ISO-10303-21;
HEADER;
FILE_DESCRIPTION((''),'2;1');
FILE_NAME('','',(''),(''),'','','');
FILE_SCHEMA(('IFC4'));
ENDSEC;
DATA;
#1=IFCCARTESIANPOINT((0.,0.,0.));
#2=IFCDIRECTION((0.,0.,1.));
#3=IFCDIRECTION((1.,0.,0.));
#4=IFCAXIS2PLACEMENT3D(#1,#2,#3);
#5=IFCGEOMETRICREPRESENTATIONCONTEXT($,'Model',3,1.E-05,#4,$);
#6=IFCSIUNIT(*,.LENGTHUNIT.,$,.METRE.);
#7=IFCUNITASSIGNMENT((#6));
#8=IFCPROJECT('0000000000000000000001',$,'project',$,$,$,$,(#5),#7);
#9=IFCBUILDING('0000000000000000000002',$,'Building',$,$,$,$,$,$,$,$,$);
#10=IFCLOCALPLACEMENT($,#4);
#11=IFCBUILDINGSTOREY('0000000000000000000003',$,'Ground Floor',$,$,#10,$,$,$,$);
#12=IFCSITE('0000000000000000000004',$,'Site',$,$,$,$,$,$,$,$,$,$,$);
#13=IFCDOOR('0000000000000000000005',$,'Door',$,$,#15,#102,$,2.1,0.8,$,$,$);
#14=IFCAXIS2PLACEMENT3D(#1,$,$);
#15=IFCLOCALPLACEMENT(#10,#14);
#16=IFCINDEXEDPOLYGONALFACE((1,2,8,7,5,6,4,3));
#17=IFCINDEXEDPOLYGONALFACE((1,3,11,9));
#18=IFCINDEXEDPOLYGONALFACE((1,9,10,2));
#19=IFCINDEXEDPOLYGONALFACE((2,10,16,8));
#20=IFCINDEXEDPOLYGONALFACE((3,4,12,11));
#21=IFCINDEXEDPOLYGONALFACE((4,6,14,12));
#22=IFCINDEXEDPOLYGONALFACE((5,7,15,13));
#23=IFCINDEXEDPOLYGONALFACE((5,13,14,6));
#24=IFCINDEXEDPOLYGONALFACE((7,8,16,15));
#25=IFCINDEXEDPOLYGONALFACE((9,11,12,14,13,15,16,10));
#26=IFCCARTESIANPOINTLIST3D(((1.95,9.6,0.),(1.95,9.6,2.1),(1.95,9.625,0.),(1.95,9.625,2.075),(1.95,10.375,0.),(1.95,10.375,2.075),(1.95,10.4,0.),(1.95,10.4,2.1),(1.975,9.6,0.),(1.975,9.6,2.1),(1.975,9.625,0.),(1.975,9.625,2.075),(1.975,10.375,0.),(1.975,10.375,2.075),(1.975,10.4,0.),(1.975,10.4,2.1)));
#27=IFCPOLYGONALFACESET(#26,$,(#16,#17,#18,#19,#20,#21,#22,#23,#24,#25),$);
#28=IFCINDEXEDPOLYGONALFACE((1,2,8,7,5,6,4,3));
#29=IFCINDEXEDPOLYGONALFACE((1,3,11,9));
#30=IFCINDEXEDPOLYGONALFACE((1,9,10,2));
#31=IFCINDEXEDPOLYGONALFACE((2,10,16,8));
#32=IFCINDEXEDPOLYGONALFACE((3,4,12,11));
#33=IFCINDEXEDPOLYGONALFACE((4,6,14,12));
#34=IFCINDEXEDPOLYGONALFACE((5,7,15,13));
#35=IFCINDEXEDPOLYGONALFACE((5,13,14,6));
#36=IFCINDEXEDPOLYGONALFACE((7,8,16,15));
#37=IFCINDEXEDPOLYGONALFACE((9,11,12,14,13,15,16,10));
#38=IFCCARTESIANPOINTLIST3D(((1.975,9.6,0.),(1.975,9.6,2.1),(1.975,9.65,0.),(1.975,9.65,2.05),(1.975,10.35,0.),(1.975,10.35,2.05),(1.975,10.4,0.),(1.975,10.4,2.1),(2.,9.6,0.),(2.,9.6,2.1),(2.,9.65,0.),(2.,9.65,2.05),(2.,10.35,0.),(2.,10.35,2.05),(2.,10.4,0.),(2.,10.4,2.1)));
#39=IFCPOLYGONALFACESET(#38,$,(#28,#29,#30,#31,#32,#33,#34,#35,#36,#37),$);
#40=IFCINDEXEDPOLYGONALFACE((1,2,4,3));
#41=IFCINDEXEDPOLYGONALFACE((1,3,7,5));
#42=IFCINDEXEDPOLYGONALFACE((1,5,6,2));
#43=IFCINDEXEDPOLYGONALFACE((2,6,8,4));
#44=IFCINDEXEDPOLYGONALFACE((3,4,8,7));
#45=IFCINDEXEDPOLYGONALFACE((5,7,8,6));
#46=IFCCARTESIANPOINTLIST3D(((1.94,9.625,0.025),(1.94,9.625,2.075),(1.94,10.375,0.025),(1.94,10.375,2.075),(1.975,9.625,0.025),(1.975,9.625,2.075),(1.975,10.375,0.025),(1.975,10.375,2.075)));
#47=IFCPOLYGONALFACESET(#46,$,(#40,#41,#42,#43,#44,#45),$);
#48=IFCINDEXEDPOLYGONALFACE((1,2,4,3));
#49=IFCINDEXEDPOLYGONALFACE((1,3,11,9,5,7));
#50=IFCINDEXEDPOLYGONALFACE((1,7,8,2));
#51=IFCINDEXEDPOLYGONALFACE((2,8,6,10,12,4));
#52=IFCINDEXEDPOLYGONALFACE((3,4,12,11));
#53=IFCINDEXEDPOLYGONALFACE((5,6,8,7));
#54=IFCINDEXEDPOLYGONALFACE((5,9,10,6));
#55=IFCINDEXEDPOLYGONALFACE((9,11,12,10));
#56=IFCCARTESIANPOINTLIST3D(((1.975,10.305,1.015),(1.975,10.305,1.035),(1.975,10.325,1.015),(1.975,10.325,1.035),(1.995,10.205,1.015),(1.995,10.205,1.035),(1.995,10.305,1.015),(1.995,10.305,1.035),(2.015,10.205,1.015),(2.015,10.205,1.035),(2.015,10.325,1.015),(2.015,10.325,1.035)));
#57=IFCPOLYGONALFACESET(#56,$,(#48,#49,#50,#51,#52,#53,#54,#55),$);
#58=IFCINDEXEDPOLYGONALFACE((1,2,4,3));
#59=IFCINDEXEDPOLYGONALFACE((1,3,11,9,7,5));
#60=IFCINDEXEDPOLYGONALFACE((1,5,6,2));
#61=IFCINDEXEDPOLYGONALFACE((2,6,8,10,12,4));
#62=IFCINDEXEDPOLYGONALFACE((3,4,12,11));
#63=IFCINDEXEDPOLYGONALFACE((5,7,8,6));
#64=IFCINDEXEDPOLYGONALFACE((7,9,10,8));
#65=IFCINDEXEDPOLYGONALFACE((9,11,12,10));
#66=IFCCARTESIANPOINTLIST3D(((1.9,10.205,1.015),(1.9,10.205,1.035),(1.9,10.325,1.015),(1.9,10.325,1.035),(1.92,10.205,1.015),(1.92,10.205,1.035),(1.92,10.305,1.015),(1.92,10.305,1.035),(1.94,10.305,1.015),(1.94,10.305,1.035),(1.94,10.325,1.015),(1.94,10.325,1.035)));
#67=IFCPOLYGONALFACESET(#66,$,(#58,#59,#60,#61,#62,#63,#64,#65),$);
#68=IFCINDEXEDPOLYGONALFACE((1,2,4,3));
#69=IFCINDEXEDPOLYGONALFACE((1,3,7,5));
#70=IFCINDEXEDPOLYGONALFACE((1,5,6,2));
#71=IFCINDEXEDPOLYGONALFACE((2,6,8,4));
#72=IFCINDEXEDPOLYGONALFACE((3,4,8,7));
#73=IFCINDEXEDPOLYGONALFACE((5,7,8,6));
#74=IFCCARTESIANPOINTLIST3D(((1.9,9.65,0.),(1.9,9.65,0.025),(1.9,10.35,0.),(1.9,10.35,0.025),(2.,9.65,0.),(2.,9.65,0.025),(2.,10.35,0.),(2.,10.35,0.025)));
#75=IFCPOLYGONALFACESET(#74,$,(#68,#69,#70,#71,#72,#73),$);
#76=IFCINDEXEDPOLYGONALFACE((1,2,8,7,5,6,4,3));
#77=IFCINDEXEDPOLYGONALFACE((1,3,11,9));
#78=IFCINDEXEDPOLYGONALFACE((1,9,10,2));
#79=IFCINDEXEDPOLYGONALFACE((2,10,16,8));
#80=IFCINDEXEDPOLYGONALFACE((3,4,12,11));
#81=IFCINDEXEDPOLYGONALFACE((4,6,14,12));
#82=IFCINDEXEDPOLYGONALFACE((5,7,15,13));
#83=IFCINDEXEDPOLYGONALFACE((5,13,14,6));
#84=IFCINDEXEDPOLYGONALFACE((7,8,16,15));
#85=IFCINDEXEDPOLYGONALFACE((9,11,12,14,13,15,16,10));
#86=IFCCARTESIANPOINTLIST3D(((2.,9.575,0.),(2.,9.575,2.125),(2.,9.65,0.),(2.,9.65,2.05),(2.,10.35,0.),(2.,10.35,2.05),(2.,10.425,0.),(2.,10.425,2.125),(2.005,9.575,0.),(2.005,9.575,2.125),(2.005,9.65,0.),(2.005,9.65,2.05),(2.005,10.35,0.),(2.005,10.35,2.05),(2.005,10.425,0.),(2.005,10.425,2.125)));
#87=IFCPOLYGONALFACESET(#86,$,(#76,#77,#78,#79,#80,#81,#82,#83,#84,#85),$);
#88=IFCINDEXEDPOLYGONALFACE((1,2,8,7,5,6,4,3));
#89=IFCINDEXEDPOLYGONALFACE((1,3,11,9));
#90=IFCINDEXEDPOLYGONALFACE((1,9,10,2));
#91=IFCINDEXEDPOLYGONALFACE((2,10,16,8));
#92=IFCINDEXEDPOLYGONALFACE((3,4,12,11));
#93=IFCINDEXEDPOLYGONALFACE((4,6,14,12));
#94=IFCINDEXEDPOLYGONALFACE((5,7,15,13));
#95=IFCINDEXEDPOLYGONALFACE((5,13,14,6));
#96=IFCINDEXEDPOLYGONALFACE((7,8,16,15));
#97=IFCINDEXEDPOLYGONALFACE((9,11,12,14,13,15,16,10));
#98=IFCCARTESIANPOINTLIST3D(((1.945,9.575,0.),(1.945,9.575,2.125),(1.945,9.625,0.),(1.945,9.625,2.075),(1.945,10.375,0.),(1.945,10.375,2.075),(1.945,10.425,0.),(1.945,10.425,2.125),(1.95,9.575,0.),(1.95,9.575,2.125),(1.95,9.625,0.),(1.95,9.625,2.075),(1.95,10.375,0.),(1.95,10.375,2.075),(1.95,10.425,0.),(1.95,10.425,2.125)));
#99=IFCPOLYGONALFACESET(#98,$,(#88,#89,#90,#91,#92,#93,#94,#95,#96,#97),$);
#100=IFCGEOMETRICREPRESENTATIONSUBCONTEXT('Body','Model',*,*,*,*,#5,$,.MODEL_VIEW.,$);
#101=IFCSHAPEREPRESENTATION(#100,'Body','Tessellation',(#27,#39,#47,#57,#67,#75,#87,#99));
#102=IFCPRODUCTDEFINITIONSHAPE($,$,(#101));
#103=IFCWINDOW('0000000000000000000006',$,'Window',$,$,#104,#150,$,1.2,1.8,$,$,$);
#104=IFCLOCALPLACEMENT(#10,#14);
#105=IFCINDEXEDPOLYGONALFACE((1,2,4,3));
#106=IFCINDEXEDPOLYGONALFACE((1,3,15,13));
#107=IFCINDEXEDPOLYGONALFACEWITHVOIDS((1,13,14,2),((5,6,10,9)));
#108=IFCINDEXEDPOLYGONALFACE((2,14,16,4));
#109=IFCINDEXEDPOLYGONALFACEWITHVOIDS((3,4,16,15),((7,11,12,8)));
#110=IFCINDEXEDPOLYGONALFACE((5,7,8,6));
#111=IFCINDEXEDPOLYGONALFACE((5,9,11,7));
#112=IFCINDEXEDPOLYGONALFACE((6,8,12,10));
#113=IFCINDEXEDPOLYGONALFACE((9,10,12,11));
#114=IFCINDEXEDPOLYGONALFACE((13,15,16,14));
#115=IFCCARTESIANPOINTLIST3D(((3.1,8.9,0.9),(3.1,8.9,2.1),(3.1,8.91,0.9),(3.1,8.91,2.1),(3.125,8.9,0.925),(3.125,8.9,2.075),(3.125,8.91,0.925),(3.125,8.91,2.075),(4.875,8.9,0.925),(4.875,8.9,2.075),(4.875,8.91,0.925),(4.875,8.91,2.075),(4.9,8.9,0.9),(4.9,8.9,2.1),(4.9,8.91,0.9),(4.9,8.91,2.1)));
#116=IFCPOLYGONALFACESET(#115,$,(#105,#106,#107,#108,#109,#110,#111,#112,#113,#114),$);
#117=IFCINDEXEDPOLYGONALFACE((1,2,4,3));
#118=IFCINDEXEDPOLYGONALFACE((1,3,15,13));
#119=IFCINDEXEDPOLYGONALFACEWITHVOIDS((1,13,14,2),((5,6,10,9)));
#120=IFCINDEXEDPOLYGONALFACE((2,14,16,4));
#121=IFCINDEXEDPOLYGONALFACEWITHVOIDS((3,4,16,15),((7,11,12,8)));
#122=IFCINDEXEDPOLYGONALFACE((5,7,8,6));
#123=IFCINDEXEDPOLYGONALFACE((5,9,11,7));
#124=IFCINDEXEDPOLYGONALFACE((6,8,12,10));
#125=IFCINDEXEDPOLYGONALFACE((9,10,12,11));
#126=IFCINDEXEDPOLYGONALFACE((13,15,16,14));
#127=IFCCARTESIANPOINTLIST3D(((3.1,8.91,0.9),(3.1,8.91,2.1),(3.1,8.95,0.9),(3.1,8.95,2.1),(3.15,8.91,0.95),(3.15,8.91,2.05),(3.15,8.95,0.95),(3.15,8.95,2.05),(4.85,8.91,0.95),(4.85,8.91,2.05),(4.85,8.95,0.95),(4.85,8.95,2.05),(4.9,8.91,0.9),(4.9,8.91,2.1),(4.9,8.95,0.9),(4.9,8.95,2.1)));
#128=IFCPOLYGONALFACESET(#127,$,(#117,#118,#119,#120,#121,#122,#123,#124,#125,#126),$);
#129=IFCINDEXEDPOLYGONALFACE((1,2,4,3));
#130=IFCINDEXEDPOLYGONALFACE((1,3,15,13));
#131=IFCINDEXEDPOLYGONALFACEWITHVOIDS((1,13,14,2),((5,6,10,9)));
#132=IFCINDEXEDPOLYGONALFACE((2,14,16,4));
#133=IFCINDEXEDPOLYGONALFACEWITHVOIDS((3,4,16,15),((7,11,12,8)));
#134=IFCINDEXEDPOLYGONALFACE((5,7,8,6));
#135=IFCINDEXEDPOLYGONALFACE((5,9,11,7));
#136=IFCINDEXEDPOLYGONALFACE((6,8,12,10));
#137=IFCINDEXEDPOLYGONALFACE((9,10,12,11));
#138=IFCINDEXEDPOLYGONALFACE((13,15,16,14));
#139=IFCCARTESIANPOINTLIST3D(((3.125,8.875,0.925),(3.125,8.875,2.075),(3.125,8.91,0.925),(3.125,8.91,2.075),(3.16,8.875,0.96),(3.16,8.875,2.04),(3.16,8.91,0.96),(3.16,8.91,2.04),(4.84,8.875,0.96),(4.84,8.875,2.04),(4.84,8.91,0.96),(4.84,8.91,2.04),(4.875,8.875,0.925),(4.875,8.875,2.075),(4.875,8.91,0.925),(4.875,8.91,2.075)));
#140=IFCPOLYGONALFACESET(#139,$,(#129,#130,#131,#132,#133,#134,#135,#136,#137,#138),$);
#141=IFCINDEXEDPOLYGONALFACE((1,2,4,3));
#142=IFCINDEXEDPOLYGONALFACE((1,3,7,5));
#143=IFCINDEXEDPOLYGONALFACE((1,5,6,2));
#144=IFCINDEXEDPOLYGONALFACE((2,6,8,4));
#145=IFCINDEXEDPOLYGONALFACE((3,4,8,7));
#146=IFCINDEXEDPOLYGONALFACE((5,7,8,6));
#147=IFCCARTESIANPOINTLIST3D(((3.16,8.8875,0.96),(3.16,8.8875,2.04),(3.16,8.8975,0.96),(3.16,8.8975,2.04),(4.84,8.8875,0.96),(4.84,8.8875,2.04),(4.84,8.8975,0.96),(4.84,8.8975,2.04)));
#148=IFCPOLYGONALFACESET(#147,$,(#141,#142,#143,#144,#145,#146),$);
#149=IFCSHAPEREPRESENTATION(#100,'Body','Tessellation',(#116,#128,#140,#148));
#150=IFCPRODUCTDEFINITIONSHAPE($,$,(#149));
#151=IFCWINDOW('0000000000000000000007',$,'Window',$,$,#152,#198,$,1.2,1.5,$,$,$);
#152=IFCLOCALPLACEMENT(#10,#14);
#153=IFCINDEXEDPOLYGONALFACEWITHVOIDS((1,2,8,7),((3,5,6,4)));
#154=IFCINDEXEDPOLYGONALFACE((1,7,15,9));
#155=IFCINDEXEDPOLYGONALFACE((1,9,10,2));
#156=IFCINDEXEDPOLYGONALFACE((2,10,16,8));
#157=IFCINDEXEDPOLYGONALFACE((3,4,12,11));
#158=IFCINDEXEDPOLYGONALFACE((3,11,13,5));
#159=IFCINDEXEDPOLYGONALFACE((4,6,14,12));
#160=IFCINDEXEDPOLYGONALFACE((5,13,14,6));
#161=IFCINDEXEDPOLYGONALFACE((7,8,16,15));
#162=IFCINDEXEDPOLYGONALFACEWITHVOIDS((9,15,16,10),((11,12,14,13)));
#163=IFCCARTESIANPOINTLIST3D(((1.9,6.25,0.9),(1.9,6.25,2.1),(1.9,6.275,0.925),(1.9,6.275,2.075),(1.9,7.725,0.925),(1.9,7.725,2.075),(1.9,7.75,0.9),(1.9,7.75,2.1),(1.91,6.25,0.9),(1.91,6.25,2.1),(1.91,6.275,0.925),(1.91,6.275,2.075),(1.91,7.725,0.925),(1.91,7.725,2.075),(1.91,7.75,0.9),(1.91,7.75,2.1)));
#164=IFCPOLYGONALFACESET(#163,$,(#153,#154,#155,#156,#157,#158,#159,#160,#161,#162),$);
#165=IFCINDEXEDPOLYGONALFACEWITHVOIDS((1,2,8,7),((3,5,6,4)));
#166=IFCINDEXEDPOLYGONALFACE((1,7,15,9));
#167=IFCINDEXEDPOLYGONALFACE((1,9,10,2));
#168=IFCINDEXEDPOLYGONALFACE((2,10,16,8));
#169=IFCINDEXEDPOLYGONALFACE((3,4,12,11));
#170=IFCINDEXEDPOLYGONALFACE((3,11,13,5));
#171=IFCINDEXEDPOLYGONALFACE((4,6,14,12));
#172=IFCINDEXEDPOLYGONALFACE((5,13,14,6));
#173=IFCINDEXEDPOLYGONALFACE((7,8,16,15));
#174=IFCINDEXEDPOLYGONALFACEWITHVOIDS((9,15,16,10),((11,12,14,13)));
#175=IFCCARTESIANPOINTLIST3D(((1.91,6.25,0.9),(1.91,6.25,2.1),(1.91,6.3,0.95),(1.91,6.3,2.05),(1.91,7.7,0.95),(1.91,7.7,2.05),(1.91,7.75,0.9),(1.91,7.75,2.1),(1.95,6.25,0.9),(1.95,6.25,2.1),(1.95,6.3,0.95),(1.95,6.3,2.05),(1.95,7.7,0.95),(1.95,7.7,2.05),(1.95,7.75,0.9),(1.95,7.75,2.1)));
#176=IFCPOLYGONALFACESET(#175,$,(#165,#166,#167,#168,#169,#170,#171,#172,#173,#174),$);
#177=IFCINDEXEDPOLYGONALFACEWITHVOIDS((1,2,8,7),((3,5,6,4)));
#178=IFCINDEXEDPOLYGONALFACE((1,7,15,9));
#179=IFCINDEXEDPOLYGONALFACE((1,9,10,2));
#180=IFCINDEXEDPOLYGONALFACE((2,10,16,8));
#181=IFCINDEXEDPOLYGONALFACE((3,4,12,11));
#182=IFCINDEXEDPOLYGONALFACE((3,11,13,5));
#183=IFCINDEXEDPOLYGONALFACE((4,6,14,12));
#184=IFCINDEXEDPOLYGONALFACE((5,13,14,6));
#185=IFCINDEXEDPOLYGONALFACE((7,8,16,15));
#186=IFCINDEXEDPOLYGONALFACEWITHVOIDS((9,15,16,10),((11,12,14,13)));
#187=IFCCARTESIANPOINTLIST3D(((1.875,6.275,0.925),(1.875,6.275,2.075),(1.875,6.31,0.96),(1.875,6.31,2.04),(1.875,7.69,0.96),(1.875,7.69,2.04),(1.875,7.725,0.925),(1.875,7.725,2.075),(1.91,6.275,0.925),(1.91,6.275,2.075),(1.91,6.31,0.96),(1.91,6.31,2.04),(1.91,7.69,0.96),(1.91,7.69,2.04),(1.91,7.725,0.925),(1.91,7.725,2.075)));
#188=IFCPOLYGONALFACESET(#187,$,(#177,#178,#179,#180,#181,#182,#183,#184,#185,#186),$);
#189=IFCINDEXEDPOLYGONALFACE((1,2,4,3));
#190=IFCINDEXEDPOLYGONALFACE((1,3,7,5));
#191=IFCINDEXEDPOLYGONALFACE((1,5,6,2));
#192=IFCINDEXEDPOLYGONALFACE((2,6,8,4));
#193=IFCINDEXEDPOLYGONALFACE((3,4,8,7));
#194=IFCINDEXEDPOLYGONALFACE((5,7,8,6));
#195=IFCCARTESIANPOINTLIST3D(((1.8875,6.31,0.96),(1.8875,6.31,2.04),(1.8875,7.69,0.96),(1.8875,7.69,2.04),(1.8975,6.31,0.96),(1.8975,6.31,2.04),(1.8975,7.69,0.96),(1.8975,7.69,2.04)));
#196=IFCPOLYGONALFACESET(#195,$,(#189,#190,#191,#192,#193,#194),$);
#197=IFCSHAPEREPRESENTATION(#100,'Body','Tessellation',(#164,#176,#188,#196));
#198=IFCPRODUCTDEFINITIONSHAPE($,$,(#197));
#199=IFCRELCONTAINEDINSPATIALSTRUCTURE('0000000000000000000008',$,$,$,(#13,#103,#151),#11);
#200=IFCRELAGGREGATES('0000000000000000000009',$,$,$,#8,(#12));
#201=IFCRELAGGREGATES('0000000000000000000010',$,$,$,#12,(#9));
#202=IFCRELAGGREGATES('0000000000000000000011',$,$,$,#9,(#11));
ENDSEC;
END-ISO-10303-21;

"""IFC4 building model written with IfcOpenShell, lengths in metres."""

from ifc_helpers import new_model, si_unit, frame, origin_with_axes, place, context, subcontext, project, spatial, line, indexed_curve, outline, extrude, element, save


model = new_model("IFC4")

# Units and contexts
model_context = context("Model", 3, precision=1e-05, world=origin_with_axes())
body_context = subcontext(model_context, "Body", "Model", "MODEL_VIEW")
ifc_project = project(units=[si_unit("LENGTHUNIT", "METRE")], contexts=[model_context])

# Site, building, storey
site = spatial("IfcSite", under=ifc_project, Name="Site")
building = spatial("IfcBuilding", under=site, Name="Building")
storey_placement = place(None, origin_with_axes())
storey = spatial("IfcBuildingStorey", under=building, at=storey_placement, Name="Ground Floor")

# Door
door_1_placement = place(storey_placement, frame((2.0, 9.6, 0.0), z_axis=(0.0, 0.0, 1.0), x_axis=(0.0, 1.0, 0.0)))
element("IfcDoor", 1, at=door_1_placement, inside=storey, Name="Door", OverallHeight=2.1, OverallWidth=0.8, context=body_context, shape_type="SweptSolid", body=[
    extrude(outline(indexed_curve([(0.0, 0.0), (0.0, 2.1), (0.8, 2.1), (0.8, 0.0), (0.775, 0.0), (0.775, 2.075), (0.025, 2.075), (0.025, 0.0)], segments=[line(1, 2, 3, 4, 5, 6, 7, 8, 1)])), frame((0.0, 0.025, 0.0), z_axis=(0.0, -1.0, 0.0), x_axis=(1.0, 0.0, 0.0)), (0.0, 0.0, -1.0), 0.025),
    extrude(outline(indexed_curve([(0.0, 0.0), (0.0, 2.1), (0.8, 2.1), (0.8, 0.0), (0.75, 0.0), (0.75, 2.05), (0.05, 2.05), (0.05, 0.0)], segments=[line(1, 2, 3, 4, 5, 6, 7, 8, 1)])), frame((0.0, 0.0, 0.0), z_axis=(0.0, -1.0, 0.0), x_axis=(1.0, 0.0, 0.0)), (0.0, 0.0, -1.0), 0.025),
    extrude(outline(indexed_curve([(0.0, 0.0), (0.75, 0.0), (0.75, 0.035), (0.0, 0.035)], segments=[line(1, 2, 3, 4, 1)])), frame((0.025, 0.025, 0.025), z_axis=(0.0, 0.0, 1.0), x_axis=(1.0, 0.0, 0.0)), (0.0, 0.0, 1.0), 2.05),
    extrude(outline(indexed_curve([(0.0, 0.0), (0.0, -0.04), (-0.12, -0.04), (-0.12, -0.02), (-0.02, -0.02), (-0.02, 0.0)], segments=[line(1, 2, 3, 4, 5, 6, 1)])), frame((0.725, 0.025, 1.015), z_axis=(0.0, 0.0, 1.0), x_axis=(1.0, 0.0, 0.0)), (0.0, 0.0, 1.0), 0.02),
    extrude(outline(indexed_curve([(0.0, 0.0), (0.0, 0.04), (-0.12, 0.04), (-0.12, 0.02), (-0.02, 0.02), (-0.02, 0.0)], segments=[line(1, 2, 3, 4, 5, 6, 1)])), frame((0.725, 0.06, 1.015), z_axis=(0.0, 0.0, 1.0), x_axis=(1.0, 0.0, 0.0)), (0.0, 0.0, 1.0), 0.02),
    extrude(outline(indexed_curve([(0.0, 0.0), (0.7, 0.0), (0.7, 0.1), (0.0, 0.1)], segments=[line(1, 2, 3, 4, 1)])), frame((0.05, 0.0, 0.0), z_axis=(0.0, 0.0, 1.0), x_axis=(1.0, 0.0, 0.0)), (0.0, 0.0, 1.0), 0.025),
    extrude(outline(indexed_curve([(0.0, 0.0), (0.0, 2.125), (0.85, 2.125), (0.85, 0.0), (0.775, 0.0), (0.775, 2.05), (0.075, 2.05), (0.075, 0.0)], segments=[line(1, 2, 3, 4, 5, 6, 7, 8, 1)])), frame((-0.025, -0.005, 0.0), z_axis=(0.0, -1.0, 0.0), x_axis=(1.0, 0.0, 0.0)), (0.0, 0.0, -1.0), 0.005),
    extrude(outline(indexed_curve([(0.0, 0.0), (0.0, 2.125), (0.85, 2.125), (0.85, 0.0), (0.8, 0.0), (0.8, 2.075), (0.05, 2.075), (0.05, 0.0)], segments=[line(1, 2, 3, 4, 5, 6, 7, 8, 1)])), frame((-0.025, 0.05, 0.0), z_axis=(0.0, -1.0, 0.0), x_axis=(1.0, 0.0, 0.0)), (0.0, 0.0, -1.0), 0.005),
])

# Windows
window_1_placement = place(storey_placement, frame((4.9, 9.0, 0.9), z_axis=(0.0, 0.0, 1.0), x_axis=(-1.0, 0.0, 0.0)))
element("IfcWindow", 2, at=window_1_placement, inside=storey, Name="Window", OverallHeight=1.2, OverallWidth=1.8, context=body_context, shape_type="SweptSolid", body=[
    extrude(outline(indexed_curve([(0.0, 0.0), (1.8, 0.0), (1.8, 1.2), (0.0, 1.2)], segments=[line(1, 2, 3, 4, 1)]), holes=[indexed_curve([(0.025, 0.025), (1.775, 0.025), (1.775, 1.175), (0.025, 1.175)], segments=[line(1, 2, 3, 4, 1)])]), frame((0.0, 0.09, 0.0), z_axis=(0.0, -1.0, 0.0), x_axis=(1.0, 0.0, 0.0)), (0.0, 0.0, -1.0), 0.01),
    extrude(outline(indexed_curve([(0.0, 0.0), (1.8, 0.0), (1.8, 1.2), (0.0, 1.2)], segments=[line(1, 2, 3, 4, 1)]), holes=[indexed_curve([(0.05, 0.05), (1.75, 0.05), (1.75, 1.15), (0.05, 1.15)], segments=[line(1, 2, 3, 4, 1)])]), frame((0.0, 0.05, 0.0), z_axis=(0.0, -1.0, 0.0), x_axis=(1.0, 0.0, 0.0)), (0.0, 0.0, -1.0), 0.04),
    extrude(outline(indexed_curve([(0.0, 0.0), (1.75, 0.0), (1.75, 1.15), (0.0, 1.15)], segments=[line(1, 2, 3, 4, 1)]), holes=[indexed_curve([(0.035, 0.035), (1.715, 0.035), (1.715, 1.115), (0.035, 1.115)], segments=[line(1, 2, 3, 4, 1)])]), frame((0.025, 0.09, 0.025), z_axis=(0.0, -1.0, 0.0), x_axis=(1.0, 0.0, 0.0)), (0.0, 0.0, -1.0), 0.035),
    extrude(outline(indexed_curve([(0.035, 0.035), (1.715, 0.035), (1.715, 1.115), (0.035, 1.115)], segments=[line(1, 2, 3, 4, 1)])), frame((0.025, 0.1025, 0.025), z_axis=(0.0, -1.0, 0.0), x_axis=(1.0, 0.0, 0.0)), (0.0, 0.0, -1.0), 0.01),
])
window_2_placement = place(storey_placement, frame((2.0, 6.25, 0.9), z_axis=(0.0, 0.0, 1.0), x_axis=(0.0, 1.0, 0.0)))
element("IfcWindow", 3, at=window_2_placement, inside=storey, Name="Window", OverallHeight=1.2, OverallWidth=1.5, context=body_context, shape_type="SweptSolid", body=[
    extrude(outline(indexed_curve([(0.0, 0.0), (1.5, 0.0), (1.5, 1.2), (0.0, 1.2)], segments=[line(1, 2, 3, 4, 1)]), holes=[indexed_curve([(0.025, 0.025), (1.475, 0.025), (1.475, 1.175), (0.025, 1.175)], segments=[line(1, 2, 3, 4, 1)])]), frame((0.0, 0.09, 0.0), z_axis=(0.0, -1.0, 0.0), x_axis=(1.0, 0.0, 0.0)), (0.0, 0.0, -1.0), 0.01),
    extrude(outline(indexed_curve([(0.0, 0.0), (1.5, 0.0), (1.5, 1.2), (0.0, 1.2)], segments=[line(1, 2, 3, 4, 1)]), holes=[indexed_curve([(0.05, 0.05), (1.45, 0.05), (1.45, 1.15), (0.05, 1.15)], segments=[line(1, 2, 3, 4, 1)])]), frame((0.0, 0.05, 0.0), z_axis=(0.0, -1.0, 0.0), x_axis=(1.0, 0.0, 0.0)), (0.0, 0.0, -1.0), 0.04),
    extrude(outline(indexed_curve([(0.0, 0.0), (1.45, 0.0), (1.45, 1.15), (0.0, 1.15)], segments=[line(1, 2, 3, 4, 1)]), holes=[indexed_curve([(0.035, 0.035), (1.415, 0.035), (1.415, 1.115), (0.035, 1.115)], segments=[line(1, 2, 3, 4, 1)])]), frame((0.025, 0.09, 0.025), z_axis=(0.0, -1.0, 0.0), x_axis=(1.0, 0.0, 0.0)), (0.0, 0.0, -1.0), 0.035),
    extrude(outline(indexed_curve([(0.035, 0.035), (1.415, 0.035), (1.415, 1.115), (0.035, 1.115)], segments=[line(1, 2, 3, 4, 1)])), frame((0.025, 0.1025, 0.025), z_axis=(0.0, -1.0, 0.0), x_axis=(1.0, 0.0, 0.0)), (0.0, 0.0, -1.0), 0.01),
])

save(model, "model.ifc")
